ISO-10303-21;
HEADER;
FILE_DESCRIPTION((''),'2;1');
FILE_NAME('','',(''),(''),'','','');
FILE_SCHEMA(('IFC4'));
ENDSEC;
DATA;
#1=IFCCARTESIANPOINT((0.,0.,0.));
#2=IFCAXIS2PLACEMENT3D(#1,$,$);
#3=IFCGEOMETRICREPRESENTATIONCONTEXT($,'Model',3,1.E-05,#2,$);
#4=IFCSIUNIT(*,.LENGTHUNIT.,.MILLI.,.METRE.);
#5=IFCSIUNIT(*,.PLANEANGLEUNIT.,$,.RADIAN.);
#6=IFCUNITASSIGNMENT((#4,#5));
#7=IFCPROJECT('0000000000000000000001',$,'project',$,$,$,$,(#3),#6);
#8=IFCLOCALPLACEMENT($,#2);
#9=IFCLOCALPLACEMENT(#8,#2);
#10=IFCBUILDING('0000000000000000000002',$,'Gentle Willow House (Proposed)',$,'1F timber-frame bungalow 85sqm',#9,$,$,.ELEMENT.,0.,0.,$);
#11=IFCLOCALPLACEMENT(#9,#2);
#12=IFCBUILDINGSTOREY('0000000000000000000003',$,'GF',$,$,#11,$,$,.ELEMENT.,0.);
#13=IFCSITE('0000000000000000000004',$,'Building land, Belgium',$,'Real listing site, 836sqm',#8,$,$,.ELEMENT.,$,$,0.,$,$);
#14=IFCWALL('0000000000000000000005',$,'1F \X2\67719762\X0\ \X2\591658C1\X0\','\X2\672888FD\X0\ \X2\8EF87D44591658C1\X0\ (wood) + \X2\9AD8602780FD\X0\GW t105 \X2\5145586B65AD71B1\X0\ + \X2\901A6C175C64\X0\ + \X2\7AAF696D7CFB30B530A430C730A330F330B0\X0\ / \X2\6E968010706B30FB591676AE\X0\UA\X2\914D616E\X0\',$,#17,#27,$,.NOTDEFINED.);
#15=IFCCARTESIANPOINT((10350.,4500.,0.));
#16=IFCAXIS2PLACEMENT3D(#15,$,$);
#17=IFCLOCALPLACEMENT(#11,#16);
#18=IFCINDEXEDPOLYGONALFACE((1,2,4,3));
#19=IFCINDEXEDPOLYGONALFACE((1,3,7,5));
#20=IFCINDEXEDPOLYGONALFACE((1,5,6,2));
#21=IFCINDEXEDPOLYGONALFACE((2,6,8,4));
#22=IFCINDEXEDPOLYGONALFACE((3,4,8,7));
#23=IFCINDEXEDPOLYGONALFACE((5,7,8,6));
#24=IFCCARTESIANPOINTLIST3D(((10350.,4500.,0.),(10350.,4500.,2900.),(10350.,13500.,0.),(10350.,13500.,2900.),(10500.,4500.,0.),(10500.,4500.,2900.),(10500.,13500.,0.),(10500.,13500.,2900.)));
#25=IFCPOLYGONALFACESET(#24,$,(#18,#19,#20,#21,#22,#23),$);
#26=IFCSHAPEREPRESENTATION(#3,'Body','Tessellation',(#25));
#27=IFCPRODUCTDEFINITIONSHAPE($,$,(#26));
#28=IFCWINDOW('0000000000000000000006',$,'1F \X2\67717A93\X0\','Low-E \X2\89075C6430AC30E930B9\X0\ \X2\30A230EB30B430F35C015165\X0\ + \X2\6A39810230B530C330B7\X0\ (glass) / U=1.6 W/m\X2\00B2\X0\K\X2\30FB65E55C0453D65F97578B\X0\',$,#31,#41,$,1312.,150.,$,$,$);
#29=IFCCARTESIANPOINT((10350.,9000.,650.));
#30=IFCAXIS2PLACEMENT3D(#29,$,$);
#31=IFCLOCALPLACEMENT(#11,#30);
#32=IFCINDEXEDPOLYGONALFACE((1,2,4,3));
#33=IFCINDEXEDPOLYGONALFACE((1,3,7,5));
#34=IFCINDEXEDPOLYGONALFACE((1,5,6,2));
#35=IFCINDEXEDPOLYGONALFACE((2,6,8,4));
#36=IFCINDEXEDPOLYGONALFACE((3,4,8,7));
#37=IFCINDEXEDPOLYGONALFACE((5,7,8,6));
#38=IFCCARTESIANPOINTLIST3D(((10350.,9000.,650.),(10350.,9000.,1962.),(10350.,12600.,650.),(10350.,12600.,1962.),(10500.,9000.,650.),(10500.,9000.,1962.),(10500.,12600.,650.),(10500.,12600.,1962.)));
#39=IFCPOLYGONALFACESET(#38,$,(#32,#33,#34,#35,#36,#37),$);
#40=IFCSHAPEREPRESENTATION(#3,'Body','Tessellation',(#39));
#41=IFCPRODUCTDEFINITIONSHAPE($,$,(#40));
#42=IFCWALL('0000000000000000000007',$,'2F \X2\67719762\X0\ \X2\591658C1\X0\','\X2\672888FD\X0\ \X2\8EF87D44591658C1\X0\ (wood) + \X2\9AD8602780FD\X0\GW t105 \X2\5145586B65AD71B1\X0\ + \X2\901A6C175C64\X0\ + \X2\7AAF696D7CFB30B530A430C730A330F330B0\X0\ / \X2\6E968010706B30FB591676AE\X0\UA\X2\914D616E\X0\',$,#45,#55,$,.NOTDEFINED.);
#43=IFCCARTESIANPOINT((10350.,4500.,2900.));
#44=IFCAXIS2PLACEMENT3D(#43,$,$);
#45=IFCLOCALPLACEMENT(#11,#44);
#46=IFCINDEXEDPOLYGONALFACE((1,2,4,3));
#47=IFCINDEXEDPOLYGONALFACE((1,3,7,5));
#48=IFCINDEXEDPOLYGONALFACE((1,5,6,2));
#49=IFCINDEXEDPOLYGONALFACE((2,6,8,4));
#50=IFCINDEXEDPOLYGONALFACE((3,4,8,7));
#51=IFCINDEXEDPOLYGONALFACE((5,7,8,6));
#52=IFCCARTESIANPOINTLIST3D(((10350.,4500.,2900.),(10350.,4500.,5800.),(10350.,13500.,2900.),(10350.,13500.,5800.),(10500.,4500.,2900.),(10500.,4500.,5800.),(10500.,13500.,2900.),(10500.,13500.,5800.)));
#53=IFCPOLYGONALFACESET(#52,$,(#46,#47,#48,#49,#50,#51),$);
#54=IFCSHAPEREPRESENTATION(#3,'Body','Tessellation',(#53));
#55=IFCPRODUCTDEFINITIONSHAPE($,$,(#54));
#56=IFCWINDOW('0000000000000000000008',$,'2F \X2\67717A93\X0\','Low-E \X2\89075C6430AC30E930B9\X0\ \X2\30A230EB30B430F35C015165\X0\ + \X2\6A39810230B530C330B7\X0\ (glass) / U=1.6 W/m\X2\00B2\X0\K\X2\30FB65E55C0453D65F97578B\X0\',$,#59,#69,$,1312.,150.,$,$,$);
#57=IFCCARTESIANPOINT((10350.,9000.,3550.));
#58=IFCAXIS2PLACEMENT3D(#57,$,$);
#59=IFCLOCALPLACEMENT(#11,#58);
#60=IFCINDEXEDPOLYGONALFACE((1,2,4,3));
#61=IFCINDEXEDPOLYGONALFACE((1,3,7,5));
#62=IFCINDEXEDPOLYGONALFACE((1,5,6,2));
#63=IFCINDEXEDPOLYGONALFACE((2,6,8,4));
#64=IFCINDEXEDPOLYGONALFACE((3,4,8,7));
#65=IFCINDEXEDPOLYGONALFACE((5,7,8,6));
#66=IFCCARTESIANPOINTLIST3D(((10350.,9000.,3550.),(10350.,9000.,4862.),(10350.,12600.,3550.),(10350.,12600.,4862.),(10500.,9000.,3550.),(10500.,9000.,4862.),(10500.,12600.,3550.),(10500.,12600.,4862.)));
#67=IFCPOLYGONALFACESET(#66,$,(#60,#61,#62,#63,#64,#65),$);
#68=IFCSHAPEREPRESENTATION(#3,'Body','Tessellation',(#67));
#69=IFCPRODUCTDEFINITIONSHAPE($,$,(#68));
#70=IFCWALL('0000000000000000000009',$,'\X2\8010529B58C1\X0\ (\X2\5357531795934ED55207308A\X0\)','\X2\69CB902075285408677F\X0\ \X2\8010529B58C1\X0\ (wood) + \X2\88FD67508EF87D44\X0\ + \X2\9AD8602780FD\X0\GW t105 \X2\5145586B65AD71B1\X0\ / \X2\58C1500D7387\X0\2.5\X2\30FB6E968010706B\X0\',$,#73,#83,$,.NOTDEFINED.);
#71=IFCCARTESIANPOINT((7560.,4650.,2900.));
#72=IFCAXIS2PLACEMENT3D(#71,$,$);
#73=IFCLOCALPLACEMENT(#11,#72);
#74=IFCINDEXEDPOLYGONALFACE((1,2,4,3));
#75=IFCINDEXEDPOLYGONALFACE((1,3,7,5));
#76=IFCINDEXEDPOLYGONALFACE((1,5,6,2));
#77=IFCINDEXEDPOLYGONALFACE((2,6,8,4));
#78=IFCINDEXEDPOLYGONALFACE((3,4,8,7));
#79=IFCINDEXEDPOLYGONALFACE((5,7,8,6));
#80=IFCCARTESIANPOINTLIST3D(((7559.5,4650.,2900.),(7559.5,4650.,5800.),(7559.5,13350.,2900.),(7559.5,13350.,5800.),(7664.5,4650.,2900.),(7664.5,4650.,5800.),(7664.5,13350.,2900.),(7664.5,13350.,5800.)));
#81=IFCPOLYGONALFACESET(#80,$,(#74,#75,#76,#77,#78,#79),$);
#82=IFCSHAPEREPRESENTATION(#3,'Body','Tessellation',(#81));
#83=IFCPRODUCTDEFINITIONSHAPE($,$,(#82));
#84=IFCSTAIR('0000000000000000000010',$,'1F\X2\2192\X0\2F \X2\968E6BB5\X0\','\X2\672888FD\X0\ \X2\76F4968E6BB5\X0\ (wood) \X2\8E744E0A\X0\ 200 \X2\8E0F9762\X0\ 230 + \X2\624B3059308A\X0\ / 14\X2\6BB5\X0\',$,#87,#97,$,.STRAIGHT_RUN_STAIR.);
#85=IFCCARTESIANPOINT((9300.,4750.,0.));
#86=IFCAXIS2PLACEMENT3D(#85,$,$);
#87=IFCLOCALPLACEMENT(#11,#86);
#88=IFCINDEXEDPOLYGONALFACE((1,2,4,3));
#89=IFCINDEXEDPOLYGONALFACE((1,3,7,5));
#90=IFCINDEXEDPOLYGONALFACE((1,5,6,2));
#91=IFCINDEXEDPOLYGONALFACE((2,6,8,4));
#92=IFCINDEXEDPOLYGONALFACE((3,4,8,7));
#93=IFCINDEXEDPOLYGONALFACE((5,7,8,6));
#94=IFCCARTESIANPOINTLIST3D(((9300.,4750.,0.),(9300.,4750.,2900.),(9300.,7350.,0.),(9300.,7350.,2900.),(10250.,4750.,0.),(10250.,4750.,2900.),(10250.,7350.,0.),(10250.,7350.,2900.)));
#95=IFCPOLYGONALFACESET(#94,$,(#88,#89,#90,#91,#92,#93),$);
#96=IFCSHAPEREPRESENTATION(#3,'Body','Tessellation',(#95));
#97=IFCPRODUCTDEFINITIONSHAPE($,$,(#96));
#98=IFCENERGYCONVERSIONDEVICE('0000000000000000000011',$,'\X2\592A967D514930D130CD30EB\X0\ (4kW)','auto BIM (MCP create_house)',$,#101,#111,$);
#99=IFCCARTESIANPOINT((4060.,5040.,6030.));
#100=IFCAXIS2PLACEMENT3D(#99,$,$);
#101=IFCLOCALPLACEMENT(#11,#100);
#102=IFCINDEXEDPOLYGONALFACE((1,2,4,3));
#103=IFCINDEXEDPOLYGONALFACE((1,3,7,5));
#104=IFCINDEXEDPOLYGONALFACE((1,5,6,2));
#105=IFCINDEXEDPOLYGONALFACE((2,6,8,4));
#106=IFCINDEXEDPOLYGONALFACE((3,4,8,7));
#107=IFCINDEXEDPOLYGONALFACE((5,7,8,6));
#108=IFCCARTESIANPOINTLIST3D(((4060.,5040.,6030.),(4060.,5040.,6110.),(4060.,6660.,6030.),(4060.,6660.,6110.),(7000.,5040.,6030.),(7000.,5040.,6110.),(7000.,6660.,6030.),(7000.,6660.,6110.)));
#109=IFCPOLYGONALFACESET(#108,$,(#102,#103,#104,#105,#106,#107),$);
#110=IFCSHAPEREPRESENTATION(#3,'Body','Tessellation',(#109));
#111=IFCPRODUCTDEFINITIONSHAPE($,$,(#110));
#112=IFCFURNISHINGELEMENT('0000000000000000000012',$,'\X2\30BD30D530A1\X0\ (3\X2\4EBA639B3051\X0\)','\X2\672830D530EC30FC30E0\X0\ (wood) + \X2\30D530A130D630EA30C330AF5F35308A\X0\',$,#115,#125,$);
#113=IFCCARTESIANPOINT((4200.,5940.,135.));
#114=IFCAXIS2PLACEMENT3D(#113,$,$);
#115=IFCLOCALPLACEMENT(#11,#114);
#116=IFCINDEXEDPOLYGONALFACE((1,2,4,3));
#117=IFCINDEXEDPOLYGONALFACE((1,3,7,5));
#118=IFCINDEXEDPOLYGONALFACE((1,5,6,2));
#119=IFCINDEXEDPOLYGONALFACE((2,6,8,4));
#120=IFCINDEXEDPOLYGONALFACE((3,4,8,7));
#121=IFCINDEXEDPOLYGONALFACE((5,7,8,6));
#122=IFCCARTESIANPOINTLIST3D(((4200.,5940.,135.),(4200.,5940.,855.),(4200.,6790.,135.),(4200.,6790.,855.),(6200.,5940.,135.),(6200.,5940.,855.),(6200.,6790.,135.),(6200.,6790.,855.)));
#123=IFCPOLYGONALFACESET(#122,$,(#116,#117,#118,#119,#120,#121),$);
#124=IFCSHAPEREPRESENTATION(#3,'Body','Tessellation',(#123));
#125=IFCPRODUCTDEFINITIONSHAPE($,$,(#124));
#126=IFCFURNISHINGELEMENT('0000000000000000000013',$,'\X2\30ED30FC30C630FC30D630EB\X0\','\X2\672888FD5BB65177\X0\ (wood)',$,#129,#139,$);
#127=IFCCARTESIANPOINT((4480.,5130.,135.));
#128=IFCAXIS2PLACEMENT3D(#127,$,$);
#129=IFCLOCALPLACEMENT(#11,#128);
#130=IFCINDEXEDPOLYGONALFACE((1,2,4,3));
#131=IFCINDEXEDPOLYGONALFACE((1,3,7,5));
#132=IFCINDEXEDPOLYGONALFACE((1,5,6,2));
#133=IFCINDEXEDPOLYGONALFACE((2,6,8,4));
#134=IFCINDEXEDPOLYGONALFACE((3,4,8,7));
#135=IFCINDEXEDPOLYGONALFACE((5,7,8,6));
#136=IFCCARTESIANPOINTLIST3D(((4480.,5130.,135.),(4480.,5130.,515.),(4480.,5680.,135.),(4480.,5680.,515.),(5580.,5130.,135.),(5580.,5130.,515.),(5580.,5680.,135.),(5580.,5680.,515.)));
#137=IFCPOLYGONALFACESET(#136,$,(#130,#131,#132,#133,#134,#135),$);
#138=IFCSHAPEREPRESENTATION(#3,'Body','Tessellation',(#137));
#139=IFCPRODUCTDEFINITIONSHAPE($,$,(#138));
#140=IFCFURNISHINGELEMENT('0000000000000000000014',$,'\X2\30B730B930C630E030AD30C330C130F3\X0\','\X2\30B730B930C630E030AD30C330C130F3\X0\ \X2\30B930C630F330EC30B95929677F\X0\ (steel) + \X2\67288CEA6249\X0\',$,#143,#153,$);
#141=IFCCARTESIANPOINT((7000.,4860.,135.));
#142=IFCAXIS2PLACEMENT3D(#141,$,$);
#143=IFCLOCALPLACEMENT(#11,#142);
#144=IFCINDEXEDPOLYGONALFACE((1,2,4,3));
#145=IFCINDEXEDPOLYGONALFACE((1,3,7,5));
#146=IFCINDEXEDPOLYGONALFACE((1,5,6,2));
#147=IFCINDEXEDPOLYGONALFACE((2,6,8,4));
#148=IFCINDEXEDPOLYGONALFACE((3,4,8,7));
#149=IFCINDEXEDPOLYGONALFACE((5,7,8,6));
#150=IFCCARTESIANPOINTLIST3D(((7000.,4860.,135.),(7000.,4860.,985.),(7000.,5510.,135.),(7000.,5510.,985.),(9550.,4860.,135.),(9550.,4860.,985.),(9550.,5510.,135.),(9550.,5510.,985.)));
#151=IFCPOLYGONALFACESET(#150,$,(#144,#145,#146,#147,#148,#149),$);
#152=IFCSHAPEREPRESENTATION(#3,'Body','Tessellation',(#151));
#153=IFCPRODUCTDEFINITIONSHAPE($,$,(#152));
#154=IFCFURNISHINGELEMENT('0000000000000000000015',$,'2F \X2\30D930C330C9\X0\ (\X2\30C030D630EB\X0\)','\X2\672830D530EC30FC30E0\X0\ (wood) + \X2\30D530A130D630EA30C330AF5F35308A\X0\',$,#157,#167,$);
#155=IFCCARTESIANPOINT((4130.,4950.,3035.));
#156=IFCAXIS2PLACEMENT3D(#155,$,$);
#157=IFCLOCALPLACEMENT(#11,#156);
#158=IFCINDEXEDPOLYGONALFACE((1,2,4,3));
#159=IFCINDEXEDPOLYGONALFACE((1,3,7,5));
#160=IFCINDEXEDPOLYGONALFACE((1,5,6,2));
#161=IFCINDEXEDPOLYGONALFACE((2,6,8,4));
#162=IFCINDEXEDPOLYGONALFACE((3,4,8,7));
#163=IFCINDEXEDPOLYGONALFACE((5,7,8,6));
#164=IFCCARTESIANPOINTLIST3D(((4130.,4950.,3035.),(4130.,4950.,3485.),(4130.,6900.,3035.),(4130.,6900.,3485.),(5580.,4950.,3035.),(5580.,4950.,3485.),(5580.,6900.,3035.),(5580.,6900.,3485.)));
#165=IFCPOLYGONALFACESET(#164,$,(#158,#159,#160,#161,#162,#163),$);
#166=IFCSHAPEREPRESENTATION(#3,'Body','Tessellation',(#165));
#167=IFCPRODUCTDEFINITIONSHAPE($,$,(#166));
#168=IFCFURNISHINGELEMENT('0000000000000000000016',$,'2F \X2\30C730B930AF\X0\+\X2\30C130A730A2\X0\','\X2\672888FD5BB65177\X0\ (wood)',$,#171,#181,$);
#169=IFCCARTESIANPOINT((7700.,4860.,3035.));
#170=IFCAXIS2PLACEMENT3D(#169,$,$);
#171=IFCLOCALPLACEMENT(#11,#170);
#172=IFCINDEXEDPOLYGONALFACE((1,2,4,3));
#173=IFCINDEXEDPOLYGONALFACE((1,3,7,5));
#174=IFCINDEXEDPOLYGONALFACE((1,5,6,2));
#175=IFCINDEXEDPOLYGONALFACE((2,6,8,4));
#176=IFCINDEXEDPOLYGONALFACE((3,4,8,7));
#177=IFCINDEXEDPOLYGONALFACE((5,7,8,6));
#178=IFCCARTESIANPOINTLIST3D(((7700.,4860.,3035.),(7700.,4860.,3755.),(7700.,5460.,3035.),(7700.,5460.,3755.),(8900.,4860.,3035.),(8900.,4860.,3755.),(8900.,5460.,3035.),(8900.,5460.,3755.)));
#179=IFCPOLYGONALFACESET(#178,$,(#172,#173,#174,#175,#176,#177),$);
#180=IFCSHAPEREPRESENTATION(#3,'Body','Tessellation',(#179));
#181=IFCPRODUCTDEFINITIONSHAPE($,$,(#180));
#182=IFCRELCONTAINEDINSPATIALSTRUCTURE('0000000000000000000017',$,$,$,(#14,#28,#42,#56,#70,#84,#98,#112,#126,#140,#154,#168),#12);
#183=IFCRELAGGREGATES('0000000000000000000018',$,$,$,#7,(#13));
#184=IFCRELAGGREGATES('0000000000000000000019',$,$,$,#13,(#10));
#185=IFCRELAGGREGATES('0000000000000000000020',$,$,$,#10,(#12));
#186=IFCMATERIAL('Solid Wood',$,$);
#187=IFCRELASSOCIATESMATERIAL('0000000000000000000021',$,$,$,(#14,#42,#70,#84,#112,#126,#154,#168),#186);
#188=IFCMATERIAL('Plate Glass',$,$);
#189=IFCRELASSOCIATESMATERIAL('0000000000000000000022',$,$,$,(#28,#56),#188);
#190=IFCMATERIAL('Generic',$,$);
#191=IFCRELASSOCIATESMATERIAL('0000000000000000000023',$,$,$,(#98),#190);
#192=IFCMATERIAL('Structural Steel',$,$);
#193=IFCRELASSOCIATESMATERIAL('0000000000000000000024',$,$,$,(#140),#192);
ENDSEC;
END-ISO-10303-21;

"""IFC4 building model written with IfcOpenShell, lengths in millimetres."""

from ifc_helpers import new_model, si_unit, frame, frame_2d, origin, place, context, project, spatial, rectangle, extrude, material, element, fill, save


model = new_model("IFC4")

# Units and contexts
model_context = context("Model", 3, precision=1e-05, world=origin())
ifc_project = project(units=[si_unit("LENGTHUNIT", "METRE", prefix="MILLI"), si_unit("PLANEANGLEUNIT", "RADIAN")], contexts=[model_context])

# Site, building, storey
site_placement = place(None, origin())
site = spatial("IfcSite", under=ifc_project, at=site_placement, Name="Building land, Belgium", ObjectType="Real listing site, 836sqm", CompositionType="ELEMENT", RefElevation=0.0)
building_placement = place(site_placement, origin())
building = spatial("IfcBuilding", under=site, at=building_placement, Name="Gentle Willow House (Proposed)", ObjectType="1F timber-frame bungalow 85sqm", CompositionType="ELEMENT", ElevationOfRefHeight=0.0, ElevationOfTerrain=0.0)
storey_placement = place(building_placement, origin())
storey = spatial("IfcBuildingStorey", under=building, at=storey_placement, Name="GF", CompositionType="ELEMENT", Elevation=0.0)

# Wall, opening, window
ifc_material_1 = material(Name="Solid Wood")
wall_1_placement = place(storey_placement, frame((10350.0, 4500.0, 0.0)))
wall_1 = element("IfcWall", 1, at=wall_1_placement, inside=storey, material=ifc_material_1, Name="1F 東面 外壁", Description="木製 軸組外壁 (wood) + 高性能GW t105 充填断熱 + 通気層 + 窯業系サイディング / 準耐火・外皮UA配慮", PredefinedType="NOTDEFINED", context=model_context, shape_type="SweptSolid", body=[
    extrude(rectangle(XDim=150.0, YDim=9000.0, at=frame_2d((75.0, 4500.0))), frame((10350.0, 4500.0, 0.0)), (0.0, 0.0, 1.0), 2900.0),
])
opening_1_placement = place(storey_placement, frame((10350.0, 9000.0, 650.0)))
opening_1 = element("IfcOpeningElement", 2, at=opening_1_placement, cuts=wall_1, PredefinedType="NOTDEFINED", context=model_context, shape_type="SweptSolid", body=[
    extrude(rectangle(XDim=150.0, YDim=3600.0, at=frame_2d((75.0, 1800.0))), frame((10350.0, 9000.0, 650.0)), (0.0, 0.0, 1.0), 1312.0),
])
ifc_material_2 = material(Name="Plate Glass")
window_1_placement = place(storey_placement, frame((10350.0, 9000.0, 650.0)))
window_1 = element("IfcWindow", 3, at=window_1_placement, inside=storey, material=ifc_material_2, Name="1F 東窓", Description="Low-E 複層ガラス アルゴン封入 + 樹脂サッシ (glass) / U=1.6 W/m²K・日射取得型", OverallHeight=1312.0, OverallWidth=150.0, context=model_context, shape_type="SweptSolid", body=[
    extrude(rectangle(XDim=150.0, YDim=3600.0, at=frame_2d((75.0, 1800.0))), frame((10350.0, 9000.0, 650.0)), (0.0, 0.0, 1.0), 1312.0),
])
fill(opening_1, window_1)

# Wall, opening, window
wall_2_placement = place(storey_placement, frame((10350.0, 4500.0, 2900.0)))
wall_2 = element("IfcWall", 4, at=wall_2_placement, inside=storey, material=ifc_material_1, Name="2F 東面 外壁", Description="木製 軸組外壁 (wood) + 高性能GW t105 充填断熱 + 通気層 + 窯業系サイディング / 準耐火・外皮UA配慮", PredefinedType="NOTDEFINED", context=model_context, shape_type="SweptSolid", body=[
    extrude(rectangle(XDim=150.0, YDim=9000.0, at=frame_2d((75.0, 4500.0))), frame((10350.0, 4500.0, 2900.0)), (0.0, 0.0, 1.0), 2900.0),
])
opening_2_placement = place(storey_placement, frame((10350.0, 9000.0, 3550.0)))
opening_2 = element("IfcOpeningElement", 5, at=opening_2_placement, cuts=wall_2, PredefinedType="NOTDEFINED", context=model_context, shape_type="SweptSolid", body=[
    extrude(rectangle(XDim=150.0, YDim=3600.0, at=frame_2d((75.0, 1800.0))), frame((10350.0, 9000.0, 3550.0)), (0.0, 0.0, 1.0), 1312.0),
])
window_2_placement = place(storey_placement, frame((10350.0, 9000.0, 3550.0)))
window_2 = element("IfcWindow", 6, at=window_2_placement, inside=storey, material=ifc_material_2, Name="2F 東窓", Description="Low-E 複層ガラス アルゴン封入 + 樹脂サッシ (glass) / U=1.6 W/m²K・日射取得型", OverallHeight=1312.0, OverallWidth=150.0, context=model_context, shape_type="SweptSolid", body=[
    extrude(rectangle(XDim=150.0, YDim=3600.0, at=frame_2d((75.0, 1800.0))), frame((10350.0, 9000.0, 3550.0)), (0.0, 0.0, 1.0), 1312.0),
])
fill(opening_2, window_2)

# Wall
wall_3_placement = place(storey_placement, frame((7560.0, 4650.0, 2900.0)))
element("IfcWall", 7, at=wall_3_placement, inside=storey, material=ifc_material_1, Name="耐力壁 (南北間仕切り)", Description="構造用合板 耐力壁 (wood) + 製材軸組 + 高性能GW t105 充填断熱 / 壁倍率2.5・準耐火", PredefinedType="NOTDEFINED", context=model_context, shape_type="SweptSolid", body=[
    extrude(rectangle(XDim=105.0, YDim=8700.0, at=frame_2d((52.0, 4350.0))), frame((7560.0, 4650.0, 2900.0)), (0.0, 0.0, 1.0), 2900.0),
])

# Stair
stair_placement = place(storey_placement, frame((9300.0, 4750.0, 0.0)))
element("IfcStair", 8, at=stair_placement, inside=storey, material=ifc_material_1, Name="1F→2F 階段", Description="木製 直階段 (wood) 蹴上 200 踏面 230 + 手すり / 14段", PredefinedType="STRAIGHT_RUN_STAIR", context=model_context, shape_type="SweptSolid", body=[
    extrude(rectangle(XDim=950.0, YDim=2600.0, at=frame_2d((475.0, 1300.0))), frame((9300.0, 4750.0, 0.0)), (0.0, 0.0, 1.0), 2900.0),
])

# Energy conversion device
ifc_material_3 = material(Name="Generic")
energy_conversion_device_placement = place(storey_placement, frame((4060.0, 5040.0, 6030.0)))
element("IfcEnergyConversionDevice", 9, at=energy_conversion_device_placement, inside=storey, material=ifc_material_3, Name="太陽光パネル (4kW)", Description="auto BIM (MCP create_house)", context=model_context, shape_type="SweptSolid", body=[
    extrude(rectangle(XDim=2940.0, YDim=1620.0, at=frame_2d((1470.0, 810.0))), frame((4060.0, 5040.0, 6030.0)), (0.0, 0.0, 1.0), 80.0),
])

# Furnishing elements
furnishing_1_placement = place(storey_placement, frame((4200.0, 5940.0, 135.0)))
element("IfcFurnishingElement", 10, at=furnishing_1_placement, inside=storey, material=ifc_material_1, Name="ソファ (3人掛け)", Description="木フレーム (wood) + ファブリック張り", context=model_context, shape_type="SweptSolid", body=[
    extrude(rectangle(XDim=2000.0, YDim=850.0, at=frame_2d((1000.0, 425.0))), frame((4200.0, 5940.0, 135.0)), (0.0, 0.0, 1.0), 720.0),
])
furnishing_2_placement = place(storey_placement, frame((4480.0, 5130.0, 135.0)))
element("IfcFurnishingElement", 11, at=furnishing_2_placement, inside=storey, material=ifc_material_1, Name="ローテーブル", Description="木製家具 (wood)", context=model_context, shape_type="SweptSolid", body=[
    extrude(rectangle(XDim=1100.0, YDim=550.0, at=frame_2d((550.0, 275.0))), frame((4480.0, 5130.0, 135.0)), (0.0, 0.0, 1.0), 380.0),
])
ifc_material_4 = material(Name="Structural Steel")
furnishing_3_placement = place(storey_placement, frame((7000.0, 4860.0, 135.0)))
element("IfcFurnishingElement", 12, at=furnishing_3_placement, inside=storey, material=ifc_material_4, Name="システムキッチン", Description="システムキッチン ステンレス天板 (steel) + 木質扉", context=model_context, shape_type="SweptSolid", body=[
    extrude(rectangle(XDim=2550.0, YDim=650.0, at=frame_2d((1275.0, 325.0))), frame((7000.0, 4860.0, 135.0)), (0.0, 0.0, 1.0), 850.0),
])
furnishing_4_placement = place(storey_placement, frame((4130.0, 4950.0, 3035.0)))
element("IfcFurnishingElement", 13, at=furnishing_4_placement, inside=storey, material=ifc_material_1, Name="2F ベッド (ダブル)", Description="木フレーム (wood) + ファブリック張り", context=model_context, shape_type="SweptSolid", body=[
    extrude(rectangle(XDim=1450.0, YDim=1950.0, at=frame_2d((725.0, 975.0))), frame((4130.0, 4950.0, 3035.0)), (0.0, 0.0, 1.0), 450.0),
])
furnishing_5_placement = place(storey_placement, frame((7700.0, 4860.0, 3035.0)))
element("IfcFurnishingElement", 14, at=furnishing_5_placement, inside=storey, material=ifc_material_1, Name="2F デスク+チェア", Description="木製家具 (wood)", context=model_context, shape_type="SweptSolid", body=[
    extrude(rectangle(XDim=1200.0, YDim=600.0, at=frame_2d((600.0, 300.0))), frame((7700.0, 4860.0, 3035.0)), (0.0, 0.0, 1.0), 720.0),
])

save(model, "model.ifc")
